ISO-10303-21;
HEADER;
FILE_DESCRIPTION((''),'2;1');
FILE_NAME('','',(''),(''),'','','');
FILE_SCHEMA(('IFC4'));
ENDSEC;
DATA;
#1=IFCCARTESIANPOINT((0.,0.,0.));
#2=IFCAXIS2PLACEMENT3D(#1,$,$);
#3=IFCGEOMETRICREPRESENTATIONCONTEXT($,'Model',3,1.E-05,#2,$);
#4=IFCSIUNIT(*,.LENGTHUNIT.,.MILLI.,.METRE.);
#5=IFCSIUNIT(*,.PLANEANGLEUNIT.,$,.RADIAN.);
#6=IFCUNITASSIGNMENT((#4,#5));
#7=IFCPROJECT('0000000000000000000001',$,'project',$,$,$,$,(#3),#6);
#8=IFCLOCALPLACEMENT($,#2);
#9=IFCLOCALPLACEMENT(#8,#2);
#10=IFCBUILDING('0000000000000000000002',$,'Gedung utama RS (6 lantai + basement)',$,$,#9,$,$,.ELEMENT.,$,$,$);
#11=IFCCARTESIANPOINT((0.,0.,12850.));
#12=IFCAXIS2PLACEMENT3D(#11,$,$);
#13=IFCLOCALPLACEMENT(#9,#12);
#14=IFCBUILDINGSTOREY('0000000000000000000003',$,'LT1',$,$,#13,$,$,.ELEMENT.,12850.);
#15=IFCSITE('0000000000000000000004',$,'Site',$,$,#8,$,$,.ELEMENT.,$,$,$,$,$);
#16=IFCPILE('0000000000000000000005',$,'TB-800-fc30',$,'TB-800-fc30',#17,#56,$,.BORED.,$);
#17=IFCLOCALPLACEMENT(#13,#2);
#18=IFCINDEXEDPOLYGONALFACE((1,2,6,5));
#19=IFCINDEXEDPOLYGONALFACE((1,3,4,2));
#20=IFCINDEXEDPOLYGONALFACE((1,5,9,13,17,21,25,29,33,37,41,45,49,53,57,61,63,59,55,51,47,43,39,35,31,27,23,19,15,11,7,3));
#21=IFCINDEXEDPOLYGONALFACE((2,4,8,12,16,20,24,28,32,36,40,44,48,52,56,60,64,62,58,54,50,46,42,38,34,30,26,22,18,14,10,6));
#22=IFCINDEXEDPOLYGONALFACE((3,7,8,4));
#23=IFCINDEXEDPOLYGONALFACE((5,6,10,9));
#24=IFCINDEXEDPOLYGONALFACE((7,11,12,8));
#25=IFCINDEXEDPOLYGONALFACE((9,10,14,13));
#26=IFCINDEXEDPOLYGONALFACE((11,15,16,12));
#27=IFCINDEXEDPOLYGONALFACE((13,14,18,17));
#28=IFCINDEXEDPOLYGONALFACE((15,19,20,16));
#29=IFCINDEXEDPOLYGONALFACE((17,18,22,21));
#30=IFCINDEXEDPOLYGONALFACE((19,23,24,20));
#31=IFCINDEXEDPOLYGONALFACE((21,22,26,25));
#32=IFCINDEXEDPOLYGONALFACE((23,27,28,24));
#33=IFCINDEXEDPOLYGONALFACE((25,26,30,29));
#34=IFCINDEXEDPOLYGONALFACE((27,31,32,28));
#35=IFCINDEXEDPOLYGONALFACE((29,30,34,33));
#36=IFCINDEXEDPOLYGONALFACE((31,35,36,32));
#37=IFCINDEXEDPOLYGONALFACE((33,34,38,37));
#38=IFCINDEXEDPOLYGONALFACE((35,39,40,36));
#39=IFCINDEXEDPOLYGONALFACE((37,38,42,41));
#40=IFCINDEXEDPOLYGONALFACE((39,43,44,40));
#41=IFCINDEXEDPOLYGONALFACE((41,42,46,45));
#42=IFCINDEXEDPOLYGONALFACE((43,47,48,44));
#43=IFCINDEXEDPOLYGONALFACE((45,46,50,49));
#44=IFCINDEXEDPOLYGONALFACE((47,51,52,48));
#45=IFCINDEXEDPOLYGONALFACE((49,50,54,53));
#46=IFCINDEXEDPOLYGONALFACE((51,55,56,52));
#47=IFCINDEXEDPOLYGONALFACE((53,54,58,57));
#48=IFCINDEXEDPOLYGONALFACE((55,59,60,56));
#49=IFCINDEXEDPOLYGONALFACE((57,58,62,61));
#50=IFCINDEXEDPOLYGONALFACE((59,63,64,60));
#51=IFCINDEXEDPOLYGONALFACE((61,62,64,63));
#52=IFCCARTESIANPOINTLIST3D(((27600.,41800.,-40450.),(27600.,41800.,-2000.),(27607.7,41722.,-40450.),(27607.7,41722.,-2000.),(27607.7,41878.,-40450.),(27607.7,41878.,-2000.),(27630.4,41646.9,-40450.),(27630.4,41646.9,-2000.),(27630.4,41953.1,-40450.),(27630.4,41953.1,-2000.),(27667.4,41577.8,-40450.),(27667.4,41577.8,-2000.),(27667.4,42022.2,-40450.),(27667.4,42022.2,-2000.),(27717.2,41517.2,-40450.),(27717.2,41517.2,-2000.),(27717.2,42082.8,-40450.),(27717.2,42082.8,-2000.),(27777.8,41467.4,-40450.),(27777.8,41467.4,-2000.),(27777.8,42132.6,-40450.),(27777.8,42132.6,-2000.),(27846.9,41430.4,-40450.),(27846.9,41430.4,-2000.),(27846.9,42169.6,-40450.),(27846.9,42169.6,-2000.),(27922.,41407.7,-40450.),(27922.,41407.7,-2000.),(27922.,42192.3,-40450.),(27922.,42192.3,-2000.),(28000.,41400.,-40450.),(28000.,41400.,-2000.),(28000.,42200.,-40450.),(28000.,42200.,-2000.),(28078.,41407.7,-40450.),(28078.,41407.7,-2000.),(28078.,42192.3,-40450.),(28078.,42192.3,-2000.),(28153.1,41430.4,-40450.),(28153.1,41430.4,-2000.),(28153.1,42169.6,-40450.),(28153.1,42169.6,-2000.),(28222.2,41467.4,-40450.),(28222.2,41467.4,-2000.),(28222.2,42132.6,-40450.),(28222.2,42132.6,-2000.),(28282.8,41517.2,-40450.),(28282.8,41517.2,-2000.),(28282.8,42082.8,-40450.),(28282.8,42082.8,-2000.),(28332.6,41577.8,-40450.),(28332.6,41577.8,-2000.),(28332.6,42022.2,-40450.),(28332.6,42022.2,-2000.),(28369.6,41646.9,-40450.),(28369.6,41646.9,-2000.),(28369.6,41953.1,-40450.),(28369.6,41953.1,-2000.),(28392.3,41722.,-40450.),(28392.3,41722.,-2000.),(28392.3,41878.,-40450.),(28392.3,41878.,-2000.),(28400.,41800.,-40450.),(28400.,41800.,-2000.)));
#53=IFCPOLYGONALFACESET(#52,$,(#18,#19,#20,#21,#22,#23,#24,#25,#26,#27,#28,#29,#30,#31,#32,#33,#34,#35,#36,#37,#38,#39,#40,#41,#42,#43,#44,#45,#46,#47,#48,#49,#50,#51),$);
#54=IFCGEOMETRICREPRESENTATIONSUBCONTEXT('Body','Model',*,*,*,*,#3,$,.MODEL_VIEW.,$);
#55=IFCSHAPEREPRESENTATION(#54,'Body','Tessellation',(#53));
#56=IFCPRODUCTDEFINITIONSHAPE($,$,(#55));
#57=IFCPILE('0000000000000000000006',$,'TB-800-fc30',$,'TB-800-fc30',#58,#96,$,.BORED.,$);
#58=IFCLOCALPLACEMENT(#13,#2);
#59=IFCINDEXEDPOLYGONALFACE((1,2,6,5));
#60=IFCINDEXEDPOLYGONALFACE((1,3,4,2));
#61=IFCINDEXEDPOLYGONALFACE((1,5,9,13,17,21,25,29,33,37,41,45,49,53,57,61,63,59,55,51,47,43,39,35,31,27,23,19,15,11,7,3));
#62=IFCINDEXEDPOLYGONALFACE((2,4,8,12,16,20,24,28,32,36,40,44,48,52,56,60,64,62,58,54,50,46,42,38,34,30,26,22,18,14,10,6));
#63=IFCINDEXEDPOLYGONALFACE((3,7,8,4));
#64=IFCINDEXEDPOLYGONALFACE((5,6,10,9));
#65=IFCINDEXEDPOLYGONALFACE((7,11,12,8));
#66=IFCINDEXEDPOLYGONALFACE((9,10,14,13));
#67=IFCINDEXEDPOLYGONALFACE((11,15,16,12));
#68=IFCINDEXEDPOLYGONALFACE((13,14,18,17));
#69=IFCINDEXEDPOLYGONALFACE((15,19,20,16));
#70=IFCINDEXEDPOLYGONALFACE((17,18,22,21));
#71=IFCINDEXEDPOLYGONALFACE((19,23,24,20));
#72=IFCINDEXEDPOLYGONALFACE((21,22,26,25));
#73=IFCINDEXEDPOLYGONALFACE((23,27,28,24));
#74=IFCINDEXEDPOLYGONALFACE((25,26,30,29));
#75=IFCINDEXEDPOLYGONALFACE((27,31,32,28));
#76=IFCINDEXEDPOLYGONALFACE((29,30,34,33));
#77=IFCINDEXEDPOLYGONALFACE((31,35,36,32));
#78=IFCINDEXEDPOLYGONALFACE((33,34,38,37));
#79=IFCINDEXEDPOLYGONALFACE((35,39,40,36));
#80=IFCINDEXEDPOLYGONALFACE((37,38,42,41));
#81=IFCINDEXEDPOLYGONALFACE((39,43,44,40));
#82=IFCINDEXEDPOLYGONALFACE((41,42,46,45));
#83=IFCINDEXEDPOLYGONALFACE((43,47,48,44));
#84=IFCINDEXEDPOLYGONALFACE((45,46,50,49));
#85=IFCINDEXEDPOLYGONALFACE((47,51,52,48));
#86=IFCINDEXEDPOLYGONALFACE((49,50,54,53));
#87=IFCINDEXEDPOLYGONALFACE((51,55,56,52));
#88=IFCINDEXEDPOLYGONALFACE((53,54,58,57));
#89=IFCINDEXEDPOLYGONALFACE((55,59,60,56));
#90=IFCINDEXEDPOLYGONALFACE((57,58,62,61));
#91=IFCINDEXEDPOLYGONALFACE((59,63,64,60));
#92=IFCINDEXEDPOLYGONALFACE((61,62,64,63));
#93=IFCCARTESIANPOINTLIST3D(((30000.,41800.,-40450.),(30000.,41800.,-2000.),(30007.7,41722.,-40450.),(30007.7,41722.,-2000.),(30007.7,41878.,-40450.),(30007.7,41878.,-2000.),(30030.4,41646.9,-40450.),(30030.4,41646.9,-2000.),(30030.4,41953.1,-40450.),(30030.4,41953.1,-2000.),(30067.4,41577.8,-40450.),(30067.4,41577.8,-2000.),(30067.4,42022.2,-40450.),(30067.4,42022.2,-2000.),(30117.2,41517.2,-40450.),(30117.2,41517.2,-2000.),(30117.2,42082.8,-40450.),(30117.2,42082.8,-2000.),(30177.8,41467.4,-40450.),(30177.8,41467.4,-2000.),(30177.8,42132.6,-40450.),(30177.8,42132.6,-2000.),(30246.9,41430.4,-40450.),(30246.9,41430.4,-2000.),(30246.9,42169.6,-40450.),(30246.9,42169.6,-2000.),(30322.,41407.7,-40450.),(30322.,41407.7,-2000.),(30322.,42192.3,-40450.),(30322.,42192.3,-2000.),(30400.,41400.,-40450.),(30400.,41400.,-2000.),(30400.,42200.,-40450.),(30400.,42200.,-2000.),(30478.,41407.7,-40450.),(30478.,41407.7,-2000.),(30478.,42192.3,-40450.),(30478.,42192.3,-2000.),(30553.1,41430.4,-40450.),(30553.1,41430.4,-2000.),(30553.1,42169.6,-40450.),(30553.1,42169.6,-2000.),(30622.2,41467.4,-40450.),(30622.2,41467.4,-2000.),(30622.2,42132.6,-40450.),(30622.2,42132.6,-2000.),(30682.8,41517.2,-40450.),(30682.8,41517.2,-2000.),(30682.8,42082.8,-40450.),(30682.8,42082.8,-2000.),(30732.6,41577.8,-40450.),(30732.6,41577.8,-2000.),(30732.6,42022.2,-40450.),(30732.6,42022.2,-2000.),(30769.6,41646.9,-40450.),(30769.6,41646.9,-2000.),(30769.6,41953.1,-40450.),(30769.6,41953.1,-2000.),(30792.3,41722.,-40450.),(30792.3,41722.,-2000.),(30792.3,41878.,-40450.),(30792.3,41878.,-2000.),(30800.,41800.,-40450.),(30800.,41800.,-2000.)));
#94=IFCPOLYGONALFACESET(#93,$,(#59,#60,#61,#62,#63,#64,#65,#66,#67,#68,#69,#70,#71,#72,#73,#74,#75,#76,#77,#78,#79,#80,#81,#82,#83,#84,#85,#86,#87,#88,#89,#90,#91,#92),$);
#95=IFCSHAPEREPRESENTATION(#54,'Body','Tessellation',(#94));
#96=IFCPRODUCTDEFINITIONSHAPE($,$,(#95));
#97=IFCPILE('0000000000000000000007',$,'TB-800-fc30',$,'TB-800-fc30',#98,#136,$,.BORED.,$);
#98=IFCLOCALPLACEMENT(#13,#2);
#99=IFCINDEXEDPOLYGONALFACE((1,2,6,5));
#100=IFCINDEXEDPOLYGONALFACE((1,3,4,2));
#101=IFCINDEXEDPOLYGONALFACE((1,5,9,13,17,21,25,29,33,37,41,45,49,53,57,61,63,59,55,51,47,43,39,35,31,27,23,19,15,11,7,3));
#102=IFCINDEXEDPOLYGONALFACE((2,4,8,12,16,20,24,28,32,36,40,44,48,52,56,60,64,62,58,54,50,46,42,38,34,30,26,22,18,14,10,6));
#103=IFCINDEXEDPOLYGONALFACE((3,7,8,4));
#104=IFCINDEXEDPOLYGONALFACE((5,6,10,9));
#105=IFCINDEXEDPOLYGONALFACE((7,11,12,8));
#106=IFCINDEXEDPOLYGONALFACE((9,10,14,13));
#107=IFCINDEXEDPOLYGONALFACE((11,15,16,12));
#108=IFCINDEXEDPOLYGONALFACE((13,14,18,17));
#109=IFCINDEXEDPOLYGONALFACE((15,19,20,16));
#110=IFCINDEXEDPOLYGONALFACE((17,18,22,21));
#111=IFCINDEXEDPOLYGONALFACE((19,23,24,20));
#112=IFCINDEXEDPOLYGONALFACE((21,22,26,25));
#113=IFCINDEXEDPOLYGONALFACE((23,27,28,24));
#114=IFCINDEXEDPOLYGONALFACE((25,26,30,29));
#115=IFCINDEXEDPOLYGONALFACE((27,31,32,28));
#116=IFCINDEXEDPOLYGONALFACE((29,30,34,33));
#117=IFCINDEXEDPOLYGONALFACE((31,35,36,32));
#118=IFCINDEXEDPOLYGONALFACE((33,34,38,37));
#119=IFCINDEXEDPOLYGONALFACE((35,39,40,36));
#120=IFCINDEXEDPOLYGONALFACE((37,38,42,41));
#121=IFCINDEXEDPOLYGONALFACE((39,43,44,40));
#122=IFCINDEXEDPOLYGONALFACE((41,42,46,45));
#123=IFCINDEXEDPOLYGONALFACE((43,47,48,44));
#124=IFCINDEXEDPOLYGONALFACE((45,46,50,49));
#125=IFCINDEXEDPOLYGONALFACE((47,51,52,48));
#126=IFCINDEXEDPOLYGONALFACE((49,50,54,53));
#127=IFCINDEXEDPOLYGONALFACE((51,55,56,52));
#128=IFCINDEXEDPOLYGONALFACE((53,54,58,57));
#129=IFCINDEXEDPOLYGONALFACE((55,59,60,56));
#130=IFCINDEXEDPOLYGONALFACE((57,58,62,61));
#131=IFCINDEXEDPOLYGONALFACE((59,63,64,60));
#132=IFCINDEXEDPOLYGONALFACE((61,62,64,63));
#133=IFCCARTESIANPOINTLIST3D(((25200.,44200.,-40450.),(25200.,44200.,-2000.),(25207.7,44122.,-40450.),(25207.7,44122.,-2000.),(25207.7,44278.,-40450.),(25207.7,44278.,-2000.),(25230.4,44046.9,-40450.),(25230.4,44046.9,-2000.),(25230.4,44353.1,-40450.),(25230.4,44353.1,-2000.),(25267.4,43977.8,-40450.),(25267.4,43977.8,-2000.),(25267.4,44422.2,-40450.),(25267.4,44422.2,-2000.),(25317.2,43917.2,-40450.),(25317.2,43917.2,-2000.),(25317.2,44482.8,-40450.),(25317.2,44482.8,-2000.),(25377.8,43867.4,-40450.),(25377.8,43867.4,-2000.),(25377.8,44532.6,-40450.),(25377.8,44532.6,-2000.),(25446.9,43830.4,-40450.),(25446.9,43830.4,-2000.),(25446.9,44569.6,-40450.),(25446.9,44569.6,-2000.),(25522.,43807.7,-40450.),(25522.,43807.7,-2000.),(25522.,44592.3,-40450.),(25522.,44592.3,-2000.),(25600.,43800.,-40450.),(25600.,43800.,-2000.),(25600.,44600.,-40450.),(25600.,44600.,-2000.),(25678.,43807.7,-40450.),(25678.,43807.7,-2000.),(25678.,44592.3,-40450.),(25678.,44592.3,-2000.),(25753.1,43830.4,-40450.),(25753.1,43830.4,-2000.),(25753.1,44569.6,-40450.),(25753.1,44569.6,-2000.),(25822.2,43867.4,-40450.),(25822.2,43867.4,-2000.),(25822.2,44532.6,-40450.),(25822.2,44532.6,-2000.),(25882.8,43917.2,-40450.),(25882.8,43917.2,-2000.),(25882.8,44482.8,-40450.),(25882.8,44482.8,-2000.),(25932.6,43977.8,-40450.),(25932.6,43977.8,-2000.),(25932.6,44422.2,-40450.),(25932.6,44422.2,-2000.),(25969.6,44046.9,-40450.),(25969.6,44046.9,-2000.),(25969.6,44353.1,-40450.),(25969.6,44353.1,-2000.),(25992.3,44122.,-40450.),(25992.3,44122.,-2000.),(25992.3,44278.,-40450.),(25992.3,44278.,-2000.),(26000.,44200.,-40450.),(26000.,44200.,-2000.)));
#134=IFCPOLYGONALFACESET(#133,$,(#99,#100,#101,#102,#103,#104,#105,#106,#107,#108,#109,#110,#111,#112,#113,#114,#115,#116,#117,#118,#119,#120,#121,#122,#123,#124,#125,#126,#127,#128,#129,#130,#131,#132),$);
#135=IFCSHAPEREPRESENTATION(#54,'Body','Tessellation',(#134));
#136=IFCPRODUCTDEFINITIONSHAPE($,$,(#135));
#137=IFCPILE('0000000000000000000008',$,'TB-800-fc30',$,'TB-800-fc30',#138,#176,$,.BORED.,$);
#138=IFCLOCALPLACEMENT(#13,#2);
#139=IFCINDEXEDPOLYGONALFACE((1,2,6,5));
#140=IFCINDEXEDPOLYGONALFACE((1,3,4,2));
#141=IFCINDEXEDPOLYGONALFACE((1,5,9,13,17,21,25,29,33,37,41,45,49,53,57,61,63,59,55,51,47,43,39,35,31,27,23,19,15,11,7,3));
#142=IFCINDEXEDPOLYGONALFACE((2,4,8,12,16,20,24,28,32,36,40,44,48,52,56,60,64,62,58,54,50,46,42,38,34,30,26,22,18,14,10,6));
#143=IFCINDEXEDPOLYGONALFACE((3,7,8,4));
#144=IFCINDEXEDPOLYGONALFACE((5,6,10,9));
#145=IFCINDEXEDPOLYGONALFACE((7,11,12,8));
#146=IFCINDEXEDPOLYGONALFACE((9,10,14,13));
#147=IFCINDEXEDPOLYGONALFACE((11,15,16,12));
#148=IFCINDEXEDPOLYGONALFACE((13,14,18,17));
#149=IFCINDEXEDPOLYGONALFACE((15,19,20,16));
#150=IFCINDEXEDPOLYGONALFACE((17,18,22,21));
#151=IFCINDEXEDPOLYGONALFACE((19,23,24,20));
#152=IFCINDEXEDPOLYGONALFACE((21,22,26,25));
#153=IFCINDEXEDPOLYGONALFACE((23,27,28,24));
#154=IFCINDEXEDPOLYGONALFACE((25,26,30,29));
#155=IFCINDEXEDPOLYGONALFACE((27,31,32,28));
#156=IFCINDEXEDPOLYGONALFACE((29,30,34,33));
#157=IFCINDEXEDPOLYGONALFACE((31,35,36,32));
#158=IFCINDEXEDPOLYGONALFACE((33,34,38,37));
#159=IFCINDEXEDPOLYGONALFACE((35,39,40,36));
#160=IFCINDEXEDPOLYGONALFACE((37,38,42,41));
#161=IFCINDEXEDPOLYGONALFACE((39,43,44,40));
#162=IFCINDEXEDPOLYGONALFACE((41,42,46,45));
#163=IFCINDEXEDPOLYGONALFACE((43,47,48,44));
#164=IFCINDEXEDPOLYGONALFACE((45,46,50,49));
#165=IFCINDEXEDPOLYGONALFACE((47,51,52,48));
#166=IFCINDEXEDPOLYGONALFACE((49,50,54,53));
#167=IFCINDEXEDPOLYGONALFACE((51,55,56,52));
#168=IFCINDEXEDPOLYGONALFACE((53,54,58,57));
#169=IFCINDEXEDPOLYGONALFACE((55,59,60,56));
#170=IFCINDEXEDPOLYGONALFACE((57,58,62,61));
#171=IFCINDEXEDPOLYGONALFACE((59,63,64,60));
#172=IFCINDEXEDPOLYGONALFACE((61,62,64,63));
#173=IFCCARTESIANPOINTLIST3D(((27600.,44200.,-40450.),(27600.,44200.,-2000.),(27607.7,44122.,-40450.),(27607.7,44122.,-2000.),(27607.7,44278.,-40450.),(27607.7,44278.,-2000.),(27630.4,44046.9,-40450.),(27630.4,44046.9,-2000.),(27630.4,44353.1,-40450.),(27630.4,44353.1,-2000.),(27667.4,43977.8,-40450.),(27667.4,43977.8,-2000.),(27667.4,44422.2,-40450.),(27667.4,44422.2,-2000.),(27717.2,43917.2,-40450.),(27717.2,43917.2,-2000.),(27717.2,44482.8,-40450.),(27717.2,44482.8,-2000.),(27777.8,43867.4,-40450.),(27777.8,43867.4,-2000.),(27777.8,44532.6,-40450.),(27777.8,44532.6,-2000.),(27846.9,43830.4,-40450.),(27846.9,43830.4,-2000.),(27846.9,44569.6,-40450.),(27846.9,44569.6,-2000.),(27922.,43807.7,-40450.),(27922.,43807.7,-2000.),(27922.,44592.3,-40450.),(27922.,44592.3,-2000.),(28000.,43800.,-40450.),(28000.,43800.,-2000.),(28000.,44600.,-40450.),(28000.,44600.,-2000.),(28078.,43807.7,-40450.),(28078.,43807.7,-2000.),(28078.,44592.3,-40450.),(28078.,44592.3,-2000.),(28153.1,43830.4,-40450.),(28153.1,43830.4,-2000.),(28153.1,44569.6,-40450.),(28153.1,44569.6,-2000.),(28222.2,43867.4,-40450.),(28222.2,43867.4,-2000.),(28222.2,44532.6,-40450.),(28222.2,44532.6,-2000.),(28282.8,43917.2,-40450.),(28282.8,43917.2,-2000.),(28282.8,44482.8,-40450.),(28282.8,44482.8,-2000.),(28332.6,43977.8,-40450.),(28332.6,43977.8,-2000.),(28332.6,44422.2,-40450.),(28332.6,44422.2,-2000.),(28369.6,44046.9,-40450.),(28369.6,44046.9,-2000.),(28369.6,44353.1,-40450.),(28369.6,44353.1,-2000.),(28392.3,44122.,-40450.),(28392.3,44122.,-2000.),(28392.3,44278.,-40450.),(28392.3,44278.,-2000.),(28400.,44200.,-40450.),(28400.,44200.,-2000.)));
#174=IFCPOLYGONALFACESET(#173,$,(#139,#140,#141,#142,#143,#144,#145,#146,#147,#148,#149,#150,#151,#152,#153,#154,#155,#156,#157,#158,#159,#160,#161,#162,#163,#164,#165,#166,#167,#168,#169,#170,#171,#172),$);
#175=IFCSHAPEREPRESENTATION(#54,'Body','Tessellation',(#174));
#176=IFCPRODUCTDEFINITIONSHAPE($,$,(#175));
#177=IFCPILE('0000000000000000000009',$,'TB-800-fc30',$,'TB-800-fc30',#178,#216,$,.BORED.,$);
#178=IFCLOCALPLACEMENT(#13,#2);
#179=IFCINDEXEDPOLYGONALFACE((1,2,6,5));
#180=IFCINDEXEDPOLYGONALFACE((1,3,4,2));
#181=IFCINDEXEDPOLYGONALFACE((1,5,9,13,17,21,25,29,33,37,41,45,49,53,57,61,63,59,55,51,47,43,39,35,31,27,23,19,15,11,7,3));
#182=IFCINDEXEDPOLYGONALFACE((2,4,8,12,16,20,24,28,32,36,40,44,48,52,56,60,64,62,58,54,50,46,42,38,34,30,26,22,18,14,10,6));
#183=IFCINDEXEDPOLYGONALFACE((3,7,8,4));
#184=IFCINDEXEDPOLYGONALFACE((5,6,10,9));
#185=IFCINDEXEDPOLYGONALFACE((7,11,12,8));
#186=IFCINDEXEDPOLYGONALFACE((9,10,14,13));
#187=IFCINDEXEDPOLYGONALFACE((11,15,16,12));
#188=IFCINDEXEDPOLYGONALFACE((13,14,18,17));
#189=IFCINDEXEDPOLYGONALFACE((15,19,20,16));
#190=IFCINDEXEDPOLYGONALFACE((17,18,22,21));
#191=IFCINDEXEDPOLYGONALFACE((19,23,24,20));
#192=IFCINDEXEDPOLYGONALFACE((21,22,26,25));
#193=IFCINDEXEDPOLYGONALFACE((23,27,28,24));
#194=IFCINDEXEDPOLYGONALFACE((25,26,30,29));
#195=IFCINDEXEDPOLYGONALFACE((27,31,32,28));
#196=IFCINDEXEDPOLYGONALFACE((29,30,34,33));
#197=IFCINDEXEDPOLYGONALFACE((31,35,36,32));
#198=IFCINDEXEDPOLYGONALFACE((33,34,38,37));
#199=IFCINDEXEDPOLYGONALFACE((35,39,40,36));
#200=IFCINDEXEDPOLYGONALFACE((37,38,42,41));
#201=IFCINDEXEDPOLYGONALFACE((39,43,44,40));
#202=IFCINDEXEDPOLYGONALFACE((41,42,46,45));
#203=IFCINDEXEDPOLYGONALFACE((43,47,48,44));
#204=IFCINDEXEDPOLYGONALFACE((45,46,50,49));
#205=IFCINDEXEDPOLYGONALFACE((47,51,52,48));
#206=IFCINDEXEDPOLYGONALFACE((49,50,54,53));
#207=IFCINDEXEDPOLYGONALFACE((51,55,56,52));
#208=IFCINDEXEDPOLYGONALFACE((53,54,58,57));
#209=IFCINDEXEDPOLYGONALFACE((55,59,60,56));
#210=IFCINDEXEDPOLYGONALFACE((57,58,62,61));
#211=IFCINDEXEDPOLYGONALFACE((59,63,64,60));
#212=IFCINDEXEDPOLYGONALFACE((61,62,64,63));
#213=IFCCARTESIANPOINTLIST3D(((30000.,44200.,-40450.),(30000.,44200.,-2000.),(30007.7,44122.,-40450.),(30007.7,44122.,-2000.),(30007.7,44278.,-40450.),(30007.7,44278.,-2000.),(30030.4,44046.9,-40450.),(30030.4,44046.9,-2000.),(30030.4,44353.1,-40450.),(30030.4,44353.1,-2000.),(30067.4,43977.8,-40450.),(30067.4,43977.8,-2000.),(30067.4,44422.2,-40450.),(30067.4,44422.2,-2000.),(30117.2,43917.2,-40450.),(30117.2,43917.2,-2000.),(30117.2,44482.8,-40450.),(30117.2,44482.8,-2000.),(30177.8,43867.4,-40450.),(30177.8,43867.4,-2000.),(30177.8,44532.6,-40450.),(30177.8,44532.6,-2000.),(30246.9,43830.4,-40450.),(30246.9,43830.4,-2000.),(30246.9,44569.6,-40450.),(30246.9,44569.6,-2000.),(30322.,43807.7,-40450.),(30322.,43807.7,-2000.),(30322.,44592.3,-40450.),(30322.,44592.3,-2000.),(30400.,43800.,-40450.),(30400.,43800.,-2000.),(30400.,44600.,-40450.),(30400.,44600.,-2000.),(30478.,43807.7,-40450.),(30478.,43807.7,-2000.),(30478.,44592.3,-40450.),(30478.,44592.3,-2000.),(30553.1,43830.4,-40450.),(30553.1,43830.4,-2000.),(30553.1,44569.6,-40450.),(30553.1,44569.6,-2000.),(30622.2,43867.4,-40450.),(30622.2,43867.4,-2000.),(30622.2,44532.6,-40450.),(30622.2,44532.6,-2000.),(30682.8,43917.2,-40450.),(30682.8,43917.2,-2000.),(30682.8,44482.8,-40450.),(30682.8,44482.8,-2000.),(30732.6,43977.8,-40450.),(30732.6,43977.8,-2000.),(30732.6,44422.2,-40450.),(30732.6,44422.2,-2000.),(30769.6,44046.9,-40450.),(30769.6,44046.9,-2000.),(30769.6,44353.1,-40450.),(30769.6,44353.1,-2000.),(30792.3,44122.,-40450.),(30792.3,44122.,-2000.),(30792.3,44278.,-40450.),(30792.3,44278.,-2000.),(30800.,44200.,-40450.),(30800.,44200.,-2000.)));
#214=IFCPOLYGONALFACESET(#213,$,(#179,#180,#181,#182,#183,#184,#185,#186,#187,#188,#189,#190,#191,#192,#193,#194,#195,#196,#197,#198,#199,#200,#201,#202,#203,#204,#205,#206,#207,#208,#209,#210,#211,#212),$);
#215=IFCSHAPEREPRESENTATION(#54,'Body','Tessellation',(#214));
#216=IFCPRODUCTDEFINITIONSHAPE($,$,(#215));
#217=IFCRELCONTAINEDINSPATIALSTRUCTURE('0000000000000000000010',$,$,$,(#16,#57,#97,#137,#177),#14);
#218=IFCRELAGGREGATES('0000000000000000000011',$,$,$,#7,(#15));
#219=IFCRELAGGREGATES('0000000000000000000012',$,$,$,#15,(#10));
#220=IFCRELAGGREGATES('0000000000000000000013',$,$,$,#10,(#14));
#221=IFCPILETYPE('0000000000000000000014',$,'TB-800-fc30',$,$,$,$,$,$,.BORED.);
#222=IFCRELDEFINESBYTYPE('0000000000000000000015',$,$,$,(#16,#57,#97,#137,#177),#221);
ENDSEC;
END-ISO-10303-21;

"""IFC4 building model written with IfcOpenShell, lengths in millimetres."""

from ifc_helpers import new_model, si_unit, frame, origin, origin_2d, place, context, subcontext, project, spatial, circle, extrude, material_profile, profile_set, profile_usage, type_object, element, save


model = new_model("IFC4")

# Units and contexts
model_context = context("Model", 3, precision=1e-05, world=origin())
body_context = subcontext(model_context, "Body", "Model", "MODEL_VIEW")
ifc_project = project(units=[si_unit("LENGTHUNIT", "METRE", prefix="MILLI"), si_unit("PLANEANGLEUNIT", "RADIAN")], contexts=[model_context])

# Site, building, storey
site_placement = place(None, origin())
site = spatial("IfcSite", under=ifc_project, at=site_placement, Name="Site", CompositionType="ELEMENT")
building_placement = place(site_placement, origin())
building = spatial("IfcBuilding", under=site, at=building_placement, Name="Gedung utama RS (6 lantai + basement)", CompositionType="ELEMENT")
storey_placement = place(building_placement, frame((0.0, 0.0, 12850.0)))
storey = spatial("IfcBuildingStorey", under=building, at=storey_placement, Name="LT1", CompositionType="ELEMENT", Elevation=12850.0)

# Piles
ifc_material_profile_1 = material_profile(None, circle(Radius=400.0, at=origin_2d()), Name="TB-800-fc30")
ifc_profile_set_1 = profile_set([ifc_material_profile_1], Name="TB-800-fc30")
ifc_profile_usage_1 = profile_usage(ifc_profile_set_1, cardinal=5)
pile_type = type_object("IfcPileType", Name="TB-800-fc30", PredefinedType="BORED", material=ifc_profile_set_1)
for number, where, z_axis, x_axis, name in (
    (1, (28000.0, 41800.0, -40450.0), (0.0, 0.0, 1.0), (1.0, 0.0, 0.0), "TB-800-fc30"),
    (2, (30400.0, 41800.0, -40450.0), (0.0, 0.0, 1.0), (1.0, 0.0, 0.0), "TB-800-fc30"),
    (3, (25600.0, 44200.0, -40450.0), (0.0, 0.0, 1.0), (1.0, 0.0, 0.0), "TB-800-fc30"),
    (4, (28000.0, 44200.0, -40450.0), (0.0, 0.0, 1.0), (1.0, 0.0, 0.0), "TB-800-fc30"),
    (5, (30400.0, 44200.0, -40450.0), (0.0, 0.0, 1.0), (1.0, 0.0, 0.0), "TB-800-fc30"),
):
    element("IfcPile", number, at=place(storey_placement, frame(where, z_axis=z_axis, x_axis=x_axis)), inside=storey, type_object=pile_type, material=ifc_profile_usage_1, Name=name, ObjectType="TB-800-fc30", PredefinedType="BORED", context=body_context, shape_type="SweptSolid", body=[
        extrude(circle(Radius=400.0, at=origin_2d()), origin(), (0.0, 0.0, 1.0), 38450.0),
    ])

save(model, "model.ifc")
